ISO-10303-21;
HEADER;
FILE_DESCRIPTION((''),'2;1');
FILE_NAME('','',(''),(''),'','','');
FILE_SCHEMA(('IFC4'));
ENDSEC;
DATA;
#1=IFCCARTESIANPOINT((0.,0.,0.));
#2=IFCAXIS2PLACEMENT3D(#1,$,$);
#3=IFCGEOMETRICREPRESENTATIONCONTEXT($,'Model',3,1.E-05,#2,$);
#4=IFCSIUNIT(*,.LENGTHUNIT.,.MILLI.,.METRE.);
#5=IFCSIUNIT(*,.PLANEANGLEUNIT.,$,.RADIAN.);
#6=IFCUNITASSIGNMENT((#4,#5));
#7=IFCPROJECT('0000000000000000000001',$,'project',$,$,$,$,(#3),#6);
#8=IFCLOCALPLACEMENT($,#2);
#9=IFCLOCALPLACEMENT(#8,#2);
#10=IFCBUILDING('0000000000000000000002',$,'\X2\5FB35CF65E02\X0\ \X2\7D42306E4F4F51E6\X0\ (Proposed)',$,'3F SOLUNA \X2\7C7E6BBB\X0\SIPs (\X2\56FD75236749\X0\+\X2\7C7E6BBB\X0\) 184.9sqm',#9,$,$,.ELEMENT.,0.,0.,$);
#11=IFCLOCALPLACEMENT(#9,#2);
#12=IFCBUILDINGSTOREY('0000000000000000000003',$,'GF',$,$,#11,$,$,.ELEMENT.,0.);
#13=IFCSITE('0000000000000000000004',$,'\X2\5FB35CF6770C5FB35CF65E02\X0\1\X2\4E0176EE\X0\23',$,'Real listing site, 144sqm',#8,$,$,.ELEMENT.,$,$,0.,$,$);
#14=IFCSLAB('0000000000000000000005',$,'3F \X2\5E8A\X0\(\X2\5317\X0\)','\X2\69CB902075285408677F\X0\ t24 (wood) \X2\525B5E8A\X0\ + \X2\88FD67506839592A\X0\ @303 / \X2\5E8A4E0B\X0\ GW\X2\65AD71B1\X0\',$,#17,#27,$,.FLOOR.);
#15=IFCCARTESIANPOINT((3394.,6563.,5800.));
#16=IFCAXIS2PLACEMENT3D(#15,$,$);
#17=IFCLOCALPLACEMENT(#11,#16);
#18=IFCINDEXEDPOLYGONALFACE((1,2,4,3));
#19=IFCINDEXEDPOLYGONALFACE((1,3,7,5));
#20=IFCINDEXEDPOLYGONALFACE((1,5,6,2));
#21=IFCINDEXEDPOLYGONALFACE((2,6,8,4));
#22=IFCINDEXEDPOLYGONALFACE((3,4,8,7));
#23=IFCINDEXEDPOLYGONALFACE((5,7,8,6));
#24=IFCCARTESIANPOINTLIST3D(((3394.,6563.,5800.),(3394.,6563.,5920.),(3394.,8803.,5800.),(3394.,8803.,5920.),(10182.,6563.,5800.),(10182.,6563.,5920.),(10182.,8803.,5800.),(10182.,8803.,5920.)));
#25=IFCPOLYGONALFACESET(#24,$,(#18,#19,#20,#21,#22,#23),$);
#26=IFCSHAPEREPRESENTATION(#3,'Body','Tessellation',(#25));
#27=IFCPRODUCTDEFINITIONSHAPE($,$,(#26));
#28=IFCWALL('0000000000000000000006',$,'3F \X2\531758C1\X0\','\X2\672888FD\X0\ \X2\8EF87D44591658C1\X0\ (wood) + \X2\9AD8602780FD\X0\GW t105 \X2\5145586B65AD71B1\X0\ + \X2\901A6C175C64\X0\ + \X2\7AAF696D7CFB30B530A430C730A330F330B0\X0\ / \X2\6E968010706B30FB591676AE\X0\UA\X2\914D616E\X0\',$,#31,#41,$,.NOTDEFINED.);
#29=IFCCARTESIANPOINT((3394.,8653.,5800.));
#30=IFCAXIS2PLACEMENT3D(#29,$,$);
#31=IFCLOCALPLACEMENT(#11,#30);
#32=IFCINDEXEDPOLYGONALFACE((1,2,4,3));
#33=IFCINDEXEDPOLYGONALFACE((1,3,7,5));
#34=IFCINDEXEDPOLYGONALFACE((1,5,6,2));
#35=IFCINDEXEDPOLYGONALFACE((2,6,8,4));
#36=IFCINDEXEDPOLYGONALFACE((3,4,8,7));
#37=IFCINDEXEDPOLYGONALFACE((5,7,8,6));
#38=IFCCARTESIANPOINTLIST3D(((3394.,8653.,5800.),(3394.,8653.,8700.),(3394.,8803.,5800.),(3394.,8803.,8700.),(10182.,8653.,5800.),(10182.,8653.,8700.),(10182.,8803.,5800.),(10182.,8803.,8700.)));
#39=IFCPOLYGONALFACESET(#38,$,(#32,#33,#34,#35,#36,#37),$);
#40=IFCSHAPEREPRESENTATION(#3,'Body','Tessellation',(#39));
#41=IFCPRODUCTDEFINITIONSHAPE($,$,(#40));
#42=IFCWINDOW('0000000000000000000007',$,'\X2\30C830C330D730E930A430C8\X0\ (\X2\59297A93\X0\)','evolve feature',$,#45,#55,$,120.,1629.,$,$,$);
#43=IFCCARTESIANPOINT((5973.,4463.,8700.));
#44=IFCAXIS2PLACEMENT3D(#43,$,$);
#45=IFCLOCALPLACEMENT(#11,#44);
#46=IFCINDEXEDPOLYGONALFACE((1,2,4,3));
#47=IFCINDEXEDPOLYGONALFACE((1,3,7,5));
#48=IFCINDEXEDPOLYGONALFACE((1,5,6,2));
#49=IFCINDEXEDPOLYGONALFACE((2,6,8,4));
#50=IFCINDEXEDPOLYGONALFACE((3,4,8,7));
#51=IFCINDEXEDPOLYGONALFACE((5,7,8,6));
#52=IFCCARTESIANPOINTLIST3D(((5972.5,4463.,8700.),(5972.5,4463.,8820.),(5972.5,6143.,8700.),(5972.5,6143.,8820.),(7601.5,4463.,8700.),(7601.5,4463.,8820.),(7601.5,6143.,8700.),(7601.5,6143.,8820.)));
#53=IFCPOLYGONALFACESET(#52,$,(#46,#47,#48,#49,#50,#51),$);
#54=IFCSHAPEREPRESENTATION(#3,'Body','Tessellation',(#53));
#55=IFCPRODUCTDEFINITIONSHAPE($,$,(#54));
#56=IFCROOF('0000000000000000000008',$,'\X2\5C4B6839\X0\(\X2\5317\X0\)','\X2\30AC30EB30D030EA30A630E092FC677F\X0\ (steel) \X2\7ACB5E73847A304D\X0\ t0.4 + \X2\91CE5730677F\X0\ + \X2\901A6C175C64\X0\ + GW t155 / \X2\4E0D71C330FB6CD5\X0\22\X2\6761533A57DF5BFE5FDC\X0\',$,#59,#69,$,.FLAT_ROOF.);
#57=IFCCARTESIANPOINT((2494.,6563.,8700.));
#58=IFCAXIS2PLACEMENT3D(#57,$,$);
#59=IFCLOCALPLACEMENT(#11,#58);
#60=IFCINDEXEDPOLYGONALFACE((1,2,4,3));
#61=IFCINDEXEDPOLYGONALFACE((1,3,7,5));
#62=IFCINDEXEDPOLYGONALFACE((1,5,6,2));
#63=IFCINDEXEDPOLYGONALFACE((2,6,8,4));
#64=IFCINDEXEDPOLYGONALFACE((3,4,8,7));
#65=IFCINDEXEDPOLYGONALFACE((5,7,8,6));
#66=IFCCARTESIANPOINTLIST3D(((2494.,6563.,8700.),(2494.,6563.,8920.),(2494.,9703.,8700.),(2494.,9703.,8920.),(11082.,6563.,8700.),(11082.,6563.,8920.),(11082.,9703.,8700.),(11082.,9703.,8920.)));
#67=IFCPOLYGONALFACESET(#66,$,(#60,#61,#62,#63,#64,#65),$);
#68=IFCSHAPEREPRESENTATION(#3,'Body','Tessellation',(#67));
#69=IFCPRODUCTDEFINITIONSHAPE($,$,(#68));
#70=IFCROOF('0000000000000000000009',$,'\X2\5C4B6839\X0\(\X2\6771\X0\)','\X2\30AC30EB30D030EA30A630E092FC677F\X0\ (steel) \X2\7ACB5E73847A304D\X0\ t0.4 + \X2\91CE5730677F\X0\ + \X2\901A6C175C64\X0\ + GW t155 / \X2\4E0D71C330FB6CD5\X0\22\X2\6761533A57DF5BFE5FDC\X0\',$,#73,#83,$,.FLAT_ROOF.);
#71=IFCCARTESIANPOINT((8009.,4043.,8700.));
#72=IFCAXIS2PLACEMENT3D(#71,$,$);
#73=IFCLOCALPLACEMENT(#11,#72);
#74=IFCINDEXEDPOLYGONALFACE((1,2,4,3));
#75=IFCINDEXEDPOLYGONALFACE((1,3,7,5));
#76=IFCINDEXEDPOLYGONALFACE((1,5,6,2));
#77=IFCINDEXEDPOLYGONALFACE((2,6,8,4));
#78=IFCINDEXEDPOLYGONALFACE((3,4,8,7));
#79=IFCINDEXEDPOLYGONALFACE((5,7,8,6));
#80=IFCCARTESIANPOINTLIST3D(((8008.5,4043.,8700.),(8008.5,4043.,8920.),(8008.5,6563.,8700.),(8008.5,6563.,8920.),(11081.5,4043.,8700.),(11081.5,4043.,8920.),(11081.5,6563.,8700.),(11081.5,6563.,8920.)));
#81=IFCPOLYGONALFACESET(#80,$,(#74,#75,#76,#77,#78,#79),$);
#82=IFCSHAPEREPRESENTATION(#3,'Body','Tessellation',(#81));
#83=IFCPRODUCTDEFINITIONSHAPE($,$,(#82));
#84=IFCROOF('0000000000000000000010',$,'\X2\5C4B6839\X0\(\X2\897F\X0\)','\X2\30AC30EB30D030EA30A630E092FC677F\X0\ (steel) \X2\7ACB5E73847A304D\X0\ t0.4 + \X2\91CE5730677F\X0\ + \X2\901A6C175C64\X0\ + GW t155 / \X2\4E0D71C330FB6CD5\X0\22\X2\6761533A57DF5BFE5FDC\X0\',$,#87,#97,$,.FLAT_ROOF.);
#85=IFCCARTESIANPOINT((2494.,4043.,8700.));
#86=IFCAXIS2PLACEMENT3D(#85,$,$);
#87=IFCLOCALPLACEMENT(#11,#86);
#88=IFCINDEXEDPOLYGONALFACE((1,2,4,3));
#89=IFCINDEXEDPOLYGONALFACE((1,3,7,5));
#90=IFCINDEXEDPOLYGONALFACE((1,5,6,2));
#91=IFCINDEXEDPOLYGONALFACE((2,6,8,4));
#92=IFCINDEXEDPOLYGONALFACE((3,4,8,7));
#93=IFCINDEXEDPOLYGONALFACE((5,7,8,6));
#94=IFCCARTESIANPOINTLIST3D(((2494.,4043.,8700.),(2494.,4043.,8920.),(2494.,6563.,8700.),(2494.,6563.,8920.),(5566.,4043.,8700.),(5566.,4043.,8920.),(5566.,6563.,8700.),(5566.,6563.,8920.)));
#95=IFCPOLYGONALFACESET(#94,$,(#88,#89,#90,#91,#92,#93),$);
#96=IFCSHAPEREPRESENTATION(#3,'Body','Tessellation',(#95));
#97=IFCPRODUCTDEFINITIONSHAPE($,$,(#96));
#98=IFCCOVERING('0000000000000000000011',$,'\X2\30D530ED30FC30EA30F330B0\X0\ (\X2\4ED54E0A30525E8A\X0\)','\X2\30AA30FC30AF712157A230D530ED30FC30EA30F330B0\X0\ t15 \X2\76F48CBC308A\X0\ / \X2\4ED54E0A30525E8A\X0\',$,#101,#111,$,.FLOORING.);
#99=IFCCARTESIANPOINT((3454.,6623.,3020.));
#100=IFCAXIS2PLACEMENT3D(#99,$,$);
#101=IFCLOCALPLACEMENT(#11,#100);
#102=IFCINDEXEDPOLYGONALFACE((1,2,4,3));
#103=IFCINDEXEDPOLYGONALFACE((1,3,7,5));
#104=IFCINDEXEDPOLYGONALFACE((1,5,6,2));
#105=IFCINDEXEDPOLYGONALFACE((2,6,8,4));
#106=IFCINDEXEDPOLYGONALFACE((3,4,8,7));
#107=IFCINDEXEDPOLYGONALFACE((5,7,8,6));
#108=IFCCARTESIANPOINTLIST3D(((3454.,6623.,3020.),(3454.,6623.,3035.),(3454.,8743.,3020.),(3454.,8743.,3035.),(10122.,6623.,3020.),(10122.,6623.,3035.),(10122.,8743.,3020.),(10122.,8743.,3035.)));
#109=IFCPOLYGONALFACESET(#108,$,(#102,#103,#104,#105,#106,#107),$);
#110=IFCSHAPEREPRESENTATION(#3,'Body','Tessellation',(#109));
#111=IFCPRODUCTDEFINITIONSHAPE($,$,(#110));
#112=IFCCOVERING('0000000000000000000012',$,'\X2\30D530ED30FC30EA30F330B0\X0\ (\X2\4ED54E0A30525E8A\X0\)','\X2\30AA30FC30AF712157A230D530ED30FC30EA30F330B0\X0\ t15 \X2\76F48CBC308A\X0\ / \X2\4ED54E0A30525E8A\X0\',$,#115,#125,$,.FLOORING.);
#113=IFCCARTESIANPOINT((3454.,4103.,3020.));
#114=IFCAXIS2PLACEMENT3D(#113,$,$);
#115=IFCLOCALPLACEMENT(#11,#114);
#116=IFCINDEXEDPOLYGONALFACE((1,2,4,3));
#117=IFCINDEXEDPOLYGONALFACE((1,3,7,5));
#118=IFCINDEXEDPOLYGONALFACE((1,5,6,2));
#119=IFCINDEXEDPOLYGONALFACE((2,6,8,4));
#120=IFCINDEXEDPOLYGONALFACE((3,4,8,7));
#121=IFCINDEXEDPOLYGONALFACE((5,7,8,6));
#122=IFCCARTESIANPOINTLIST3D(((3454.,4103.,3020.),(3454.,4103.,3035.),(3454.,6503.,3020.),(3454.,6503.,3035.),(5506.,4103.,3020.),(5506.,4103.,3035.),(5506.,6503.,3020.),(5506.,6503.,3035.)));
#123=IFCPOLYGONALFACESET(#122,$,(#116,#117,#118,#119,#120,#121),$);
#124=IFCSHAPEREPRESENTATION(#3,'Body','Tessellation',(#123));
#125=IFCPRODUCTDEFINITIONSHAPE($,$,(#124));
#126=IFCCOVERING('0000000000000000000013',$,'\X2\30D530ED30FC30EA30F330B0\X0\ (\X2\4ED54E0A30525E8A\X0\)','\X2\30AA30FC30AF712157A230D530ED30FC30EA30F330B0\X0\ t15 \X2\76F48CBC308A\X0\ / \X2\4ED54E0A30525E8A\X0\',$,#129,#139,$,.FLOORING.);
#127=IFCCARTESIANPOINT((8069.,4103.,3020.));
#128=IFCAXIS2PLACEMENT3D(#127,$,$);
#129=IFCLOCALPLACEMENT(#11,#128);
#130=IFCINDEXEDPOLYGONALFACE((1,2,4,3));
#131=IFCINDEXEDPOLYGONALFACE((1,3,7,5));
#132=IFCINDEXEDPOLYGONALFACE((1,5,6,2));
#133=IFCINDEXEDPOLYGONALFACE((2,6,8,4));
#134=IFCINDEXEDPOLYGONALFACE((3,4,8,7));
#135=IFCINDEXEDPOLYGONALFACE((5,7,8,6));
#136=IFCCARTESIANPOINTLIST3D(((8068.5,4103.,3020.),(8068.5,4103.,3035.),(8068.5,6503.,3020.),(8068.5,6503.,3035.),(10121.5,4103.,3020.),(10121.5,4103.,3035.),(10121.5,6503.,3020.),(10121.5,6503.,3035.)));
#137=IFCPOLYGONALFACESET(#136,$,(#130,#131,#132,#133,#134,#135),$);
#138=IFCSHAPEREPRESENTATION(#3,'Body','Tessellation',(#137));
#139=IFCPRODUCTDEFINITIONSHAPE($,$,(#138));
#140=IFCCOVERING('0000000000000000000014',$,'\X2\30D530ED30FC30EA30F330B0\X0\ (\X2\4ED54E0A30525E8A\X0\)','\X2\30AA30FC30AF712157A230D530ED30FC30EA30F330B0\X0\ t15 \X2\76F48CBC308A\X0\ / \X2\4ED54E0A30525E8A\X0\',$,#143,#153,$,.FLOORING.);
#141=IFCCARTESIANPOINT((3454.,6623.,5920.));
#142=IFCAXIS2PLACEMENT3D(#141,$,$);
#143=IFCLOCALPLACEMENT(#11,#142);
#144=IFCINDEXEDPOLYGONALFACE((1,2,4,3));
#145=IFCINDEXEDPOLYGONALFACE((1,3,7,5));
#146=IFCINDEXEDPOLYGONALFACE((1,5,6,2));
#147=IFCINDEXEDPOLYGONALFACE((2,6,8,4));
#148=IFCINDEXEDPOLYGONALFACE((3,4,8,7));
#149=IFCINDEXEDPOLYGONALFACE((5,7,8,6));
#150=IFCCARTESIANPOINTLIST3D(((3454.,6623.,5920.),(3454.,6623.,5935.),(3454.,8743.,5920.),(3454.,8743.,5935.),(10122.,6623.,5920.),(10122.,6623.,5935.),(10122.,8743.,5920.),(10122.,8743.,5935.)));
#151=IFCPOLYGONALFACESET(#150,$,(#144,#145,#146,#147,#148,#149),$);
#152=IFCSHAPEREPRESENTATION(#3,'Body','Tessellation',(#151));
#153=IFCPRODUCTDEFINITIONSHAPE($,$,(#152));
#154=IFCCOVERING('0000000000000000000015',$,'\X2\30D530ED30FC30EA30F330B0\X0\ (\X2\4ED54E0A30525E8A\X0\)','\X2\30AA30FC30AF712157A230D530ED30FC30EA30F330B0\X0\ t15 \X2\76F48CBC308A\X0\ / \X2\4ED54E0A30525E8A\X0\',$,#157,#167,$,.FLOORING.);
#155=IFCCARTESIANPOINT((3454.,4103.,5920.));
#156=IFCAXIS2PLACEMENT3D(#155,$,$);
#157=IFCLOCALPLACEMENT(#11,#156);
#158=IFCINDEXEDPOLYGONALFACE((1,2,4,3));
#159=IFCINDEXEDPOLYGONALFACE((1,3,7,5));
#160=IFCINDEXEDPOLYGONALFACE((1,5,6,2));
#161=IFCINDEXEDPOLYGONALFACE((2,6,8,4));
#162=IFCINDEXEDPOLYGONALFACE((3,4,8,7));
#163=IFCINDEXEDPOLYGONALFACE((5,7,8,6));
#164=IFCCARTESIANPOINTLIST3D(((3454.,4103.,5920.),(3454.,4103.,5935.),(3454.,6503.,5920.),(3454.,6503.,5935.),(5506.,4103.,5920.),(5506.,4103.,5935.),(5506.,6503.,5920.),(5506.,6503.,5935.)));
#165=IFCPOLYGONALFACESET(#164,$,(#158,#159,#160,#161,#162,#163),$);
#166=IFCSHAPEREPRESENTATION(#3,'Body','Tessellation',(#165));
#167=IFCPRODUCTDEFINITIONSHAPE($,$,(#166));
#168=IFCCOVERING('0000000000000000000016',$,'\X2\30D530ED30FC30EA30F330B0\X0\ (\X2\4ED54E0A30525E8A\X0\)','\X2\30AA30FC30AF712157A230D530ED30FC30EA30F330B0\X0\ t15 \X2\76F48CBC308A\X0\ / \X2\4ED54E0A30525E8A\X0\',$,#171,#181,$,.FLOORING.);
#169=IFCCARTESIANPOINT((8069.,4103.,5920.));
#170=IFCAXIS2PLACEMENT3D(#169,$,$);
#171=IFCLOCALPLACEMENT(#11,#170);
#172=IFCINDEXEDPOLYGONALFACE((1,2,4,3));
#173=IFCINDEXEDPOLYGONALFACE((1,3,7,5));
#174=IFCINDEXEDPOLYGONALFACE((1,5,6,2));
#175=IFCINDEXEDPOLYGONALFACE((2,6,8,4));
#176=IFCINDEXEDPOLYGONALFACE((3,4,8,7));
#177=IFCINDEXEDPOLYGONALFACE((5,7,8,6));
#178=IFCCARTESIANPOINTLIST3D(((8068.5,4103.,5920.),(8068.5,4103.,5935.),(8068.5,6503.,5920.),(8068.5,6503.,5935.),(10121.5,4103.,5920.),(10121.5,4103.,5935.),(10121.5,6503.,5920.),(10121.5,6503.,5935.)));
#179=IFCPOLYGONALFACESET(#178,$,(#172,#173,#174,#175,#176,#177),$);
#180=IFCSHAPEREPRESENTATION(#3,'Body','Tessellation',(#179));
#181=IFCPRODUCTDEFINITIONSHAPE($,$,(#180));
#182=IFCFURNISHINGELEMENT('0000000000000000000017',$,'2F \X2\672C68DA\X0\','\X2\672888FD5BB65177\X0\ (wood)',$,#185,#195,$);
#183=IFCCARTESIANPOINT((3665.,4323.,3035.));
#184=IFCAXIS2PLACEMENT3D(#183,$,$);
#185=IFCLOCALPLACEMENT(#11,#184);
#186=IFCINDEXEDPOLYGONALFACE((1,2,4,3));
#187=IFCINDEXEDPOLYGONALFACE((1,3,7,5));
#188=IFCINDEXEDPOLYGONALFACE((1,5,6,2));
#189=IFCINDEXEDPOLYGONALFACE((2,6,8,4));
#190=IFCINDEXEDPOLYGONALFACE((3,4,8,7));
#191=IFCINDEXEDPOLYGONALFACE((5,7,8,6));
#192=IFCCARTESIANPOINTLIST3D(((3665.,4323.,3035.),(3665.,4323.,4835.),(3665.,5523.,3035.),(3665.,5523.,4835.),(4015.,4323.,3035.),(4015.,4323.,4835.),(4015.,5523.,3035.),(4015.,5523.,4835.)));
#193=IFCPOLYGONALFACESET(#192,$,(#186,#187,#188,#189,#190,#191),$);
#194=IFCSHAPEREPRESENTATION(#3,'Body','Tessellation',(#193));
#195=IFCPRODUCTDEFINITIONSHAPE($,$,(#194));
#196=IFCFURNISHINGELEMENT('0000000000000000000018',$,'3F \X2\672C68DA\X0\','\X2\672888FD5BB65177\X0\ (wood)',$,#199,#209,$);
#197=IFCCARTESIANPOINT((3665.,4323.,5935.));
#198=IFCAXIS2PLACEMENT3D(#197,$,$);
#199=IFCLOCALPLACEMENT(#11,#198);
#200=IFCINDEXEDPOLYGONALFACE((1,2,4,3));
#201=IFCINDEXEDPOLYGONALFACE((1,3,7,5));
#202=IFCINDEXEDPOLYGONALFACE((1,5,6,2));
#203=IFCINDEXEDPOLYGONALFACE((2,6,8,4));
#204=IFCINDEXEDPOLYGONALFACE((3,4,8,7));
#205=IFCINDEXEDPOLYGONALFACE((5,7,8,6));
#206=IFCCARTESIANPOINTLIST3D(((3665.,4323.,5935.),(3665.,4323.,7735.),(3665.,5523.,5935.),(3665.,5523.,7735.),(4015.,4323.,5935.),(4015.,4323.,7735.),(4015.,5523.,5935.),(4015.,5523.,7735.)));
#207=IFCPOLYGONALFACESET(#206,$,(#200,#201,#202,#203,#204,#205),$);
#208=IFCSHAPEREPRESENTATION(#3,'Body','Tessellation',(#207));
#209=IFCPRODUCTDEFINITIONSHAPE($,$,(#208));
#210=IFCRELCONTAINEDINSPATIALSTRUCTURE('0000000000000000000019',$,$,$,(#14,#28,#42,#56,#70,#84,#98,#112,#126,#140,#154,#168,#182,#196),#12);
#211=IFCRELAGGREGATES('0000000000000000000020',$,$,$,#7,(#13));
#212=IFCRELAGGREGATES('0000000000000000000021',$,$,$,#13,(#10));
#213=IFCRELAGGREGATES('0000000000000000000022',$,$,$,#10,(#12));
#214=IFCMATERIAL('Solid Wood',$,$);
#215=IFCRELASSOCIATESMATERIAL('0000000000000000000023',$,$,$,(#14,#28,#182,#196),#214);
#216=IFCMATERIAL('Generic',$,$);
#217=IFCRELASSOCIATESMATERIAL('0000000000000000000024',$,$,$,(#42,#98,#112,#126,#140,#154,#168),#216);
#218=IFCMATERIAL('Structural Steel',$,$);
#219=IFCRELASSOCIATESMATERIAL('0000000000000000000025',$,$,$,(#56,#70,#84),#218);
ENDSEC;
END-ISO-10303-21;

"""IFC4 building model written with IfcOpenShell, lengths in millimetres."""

from ifc_helpers import new_model, si_unit, frame, frame_2d, origin, place, context, project, spatial, rectangle, extrude, material, element, save


model = new_model("IFC4")

# Units and contexts
model_context = context("Model", 3, precision=1e-05, world=origin())
ifc_project = project(units=[si_unit("LENGTHUNIT", "METRE", prefix="MILLI"), si_unit("PLANEANGLEUNIT", "RADIAN")], contexts=[model_context])

# Site, building, storey
site_placement = place(None, origin())
site = spatial("IfcSite", under=ifc_project, at=site_placement, Name="徳島県徳島市1丁目23", ObjectType="Real listing site, 144sqm", CompositionType="ELEMENT", RefElevation=0.0)
building_placement = place(site_placement, origin())
building = spatial("IfcBuilding", under=site, at=building_placement, Name="徳島市 終の住処 (Proposed)", ObjectType="3F SOLUNA 籾殻SIPs (国産杉+籾殻) 184.9sqm", CompositionType="ELEMENT", ElevationOfRefHeight=0.0, ElevationOfTerrain=0.0)
storey_placement = place(building_placement, origin())
storey = spatial("IfcBuildingStorey", under=building, at=storey_placement, Name="GF", CompositionType="ELEMENT", Elevation=0.0)

# Slab
ifc_material_1 = material(Name="Solid Wood")
slab_placement = place(storey_placement, frame((3394.0, 6563.0, 5800.0)))
element("IfcSlab", 1, at=slab_placement, inside=storey, material=ifc_material_1, Name="3F 床(北)", Description="構造用合板 t24 (wood) 剛床 + 製材根太 @303 / 床下 GW断熱", PredefinedType="FLOOR", context=model_context, shape_type="SweptSolid", body=[
    extrude(rectangle(XDim=6788.0, YDim=2240.0, at=frame_2d((3394.0, 1120.0))), frame((3394.0, 6563.0, 5800.0)), (0.0, 0.0, 1.0), 120.0),
])

# Wall
wall_1_placement = place(storey_placement, frame((3394.0, 8653.0, 5800.0)))
element("IfcWall", 2, at=wall_1_placement, inside=storey, material=ifc_material_1, Name="3F 北壁", Description="木製 軸組外壁 (wood) + 高性能GW t105 充填断熱 + 通気層 + 窯業系サイディング / 準耐火・外皮UA配慮", PredefinedType="NOTDEFINED", context=model_context, shape_type="SweptSolid", body=[
    extrude(rectangle(XDim=6788.0, YDim=150.0, at=frame_2d((3394.0, 75.0))), frame((3394.0, 8653.0, 5800.0)), (0.0, 0.0, 1.0), 2900.0),
])

# Window
ifc_material_2 = material(Name="Generic")
window_1_placement = place(storey_placement, frame((5973.0, 4463.0, 8700.0)))
element("IfcWindow", 3, at=window_1_placement, inside=storey, material=ifc_material_2, Name="トップライト (天窓)", Description="evolve feature", OverallHeight=120.0, OverallWidth=1629.0, context=model_context, shape_type="SweptSolid", body=[
    extrude(rectangle(XDim=1629.0, YDim=1680.0, at=frame_2d((814.0, 840.0))), frame((5973.0, 4463.0, 8700.0)), (0.0, 0.0, 1.0), 120.0),
])

# Roofs
ifc_material_3 = material(Name="Structural Steel")
roof_1_placement = place(storey_placement, frame((2494.0, 6563.0, 8700.0)))
element("IfcRoof", 4, at=roof_1_placement, inside=storey, material=ifc_material_3, Name="屋根(北)", Description="ガルバリウム鋼板 (steel) 立平葺き t0.4 + 野地板 + 通気層 + GW t155 / 不燃・法22条区域対応", PredefinedType="FLAT_ROOF", context=model_context, shape_type="SweptSolid", body=[
    extrude(rectangle(XDim=8588.0, YDim=3140.0, at=frame_2d((4294.0, 1570.0))), frame((2494.0, 6563.0, 8700.0)), (0.0, 0.0, 1.0), 220.0),
])
roof_2_placement = place(storey_placement, frame((8009.0, 4043.0, 8700.0)))
element("IfcRoof", 5, at=roof_2_placement, inside=storey, material=ifc_material_3, Name="屋根(東)", Description="ガルバリウム鋼板 (steel) 立平葺き t0.4 + 野地板 + 通気層 + GW t155 / 不燃・法22条区域対応", PredefinedType="FLAT_ROOF", context=model_context, shape_type="SweptSolid", body=[
    extrude(rectangle(XDim=3073.0, YDim=2520.0, at=frame_2d((1536.0, 1260.0))), frame((8009.0, 4043.0, 8700.0)), (0.0, 0.0, 1.0), 220.0),
])
roof_3_placement = place(storey_placement, frame((2494.0, 4043.0, 8700.0)))
element("IfcRoof", 6, at=roof_3_placement, inside=storey, material=ifc_material_3, Name="屋根(西)", Description="ガルバリウム鋼板 (steel) 立平葺き t0.4 + 野地板 + 通気層 + GW t155 / 不燃・法22条区域対応", PredefinedType="FLAT_ROOF", context=model_context, shape_type="SweptSolid", body=[
    extrude(rectangle(XDim=3072.0, YDim=2520.0, at=frame_2d((1536.0, 1260.0))), frame((2494.0, 4043.0, 8700.0)), (0.0, 0.0, 1.0), 220.0),
])

# Coverings
covering_1_placement = place(storey_placement, frame((3454.0, 6623.0, 3020.0)))
element("IfcCovering", 7, at=covering_1_placement, inside=storey, material=ifc_material_2, Name="フローリング (仕上げ床)", Description="オーク無垢フローリング t15 直貼り / 仕上げ床", PredefinedType="FLOORING", context=model_context, shape_type="SweptSolid", body=[
    extrude(rectangle(XDim=6668.0, YDim=2120.0, at=frame_2d((3334.0, 1060.0))), frame((3454.0, 6623.0, 3020.0)), (0.0, 0.0, 1.0), 15.0),
])
covering_2_placement = place(storey_placement, frame((3454.0, 4103.0, 3020.0)))
element("IfcCovering", 8, at=covering_2_placement, inside=storey, material=ifc_material_2, Name="フローリング (仕上げ床)", Description="オーク無垢フローリング t15 直貼り / 仕上げ床", PredefinedType="FLOORING", context=model_context, shape_type="SweptSolid", body=[
    extrude(rectangle(XDim=2052.0, YDim=2400.0, at=frame_2d((1026.0, 1200.0))), frame((3454.0, 4103.0, 3020.0)), (0.0, 0.0, 1.0), 15.0),
])
covering_3_placement = place(storey_placement, frame((8069.0, 4103.0, 3020.0)))
element("IfcCovering", 9, at=covering_3_placement, inside=storey, material=ifc_material_2, Name="フローリング (仕上げ床)", Description="オーク無垢フローリング t15 直貼り / 仕上げ床", PredefinedType="FLOORING", context=model_context, shape_type="SweptSolid", body=[
    extrude(rectangle(XDim=2053.0, YDim=2400.0, at=frame_2d((1026.0, 1200.0))), frame((8069.0, 4103.0, 3020.0)), (0.0, 0.0, 1.0), 15.0),
])
covering_4_placement = place(storey_placement, frame((3454.0, 6623.0, 5920.0)))
element("IfcCovering", 10, at=covering_4_placement, inside=storey, material=ifc_material_2, Name="フローリング (仕上げ床)", Description="オーク無垢フローリング t15 直貼り / 仕上げ床", PredefinedType="FLOORING", context=model_context, shape_type="SweptSolid", body=[
    extrude(rectangle(XDim=6668.0, YDim=2120.0, at=frame_2d((3334.0, 1060.0))), frame((3454.0, 6623.0, 5920.0)), (0.0, 0.0, 1.0), 15.0),
])
covering_5_placement = place(storey_placement, frame((3454.0, 4103.0, 5920.0)))
element("IfcCovering", 11, at=covering_5_placement, inside=storey, material=ifc_material_2, Name="フローリング (仕上げ床)", Description="オーク無垢フローリング t15 直貼り / 仕上げ床", PredefinedType="FLOORING", context=model_context, shape_type="SweptSolid", body=[
    extrude(rectangle(XDim=2052.0, YDim=2400.0, at=frame_2d((1026.0, 1200.0))), frame((3454.0, 4103.0, 5920.0)), (0.0, 0.0, 1.0), 15.0),
])
covering_6_placement = place(storey_placement, frame((8069.0, 4103.0, 5920.0)))
element("IfcCovering", 12, at=covering_6_placement, inside=storey, material=ifc_material_2, Name="フローリング (仕上げ床)", Description="オーク無垢フローリング t15 直貼り / 仕上げ床", PredefinedType="FLOORING", context=model_context, shape_type="SweptSolid", body=[
    extrude(rectangle(XDim=2053.0, YDim=2400.0, at=frame_2d((1026.0, 1200.0))), frame((8069.0, 4103.0, 5920.0)), (0.0, 0.0, 1.0), 15.0),
])

# Furnishing elements
furnishing_1_placement = place(storey_placement, frame((3665.0, 4323.0, 3035.0)))
element("IfcFurnishingElement", 13, at=furnishing_1_placement, inside=storey, material=ifc_material_1, Name="2F 本棚", Description="木製家具 (wood)", context=model_context, shape_type="SweptSolid", body=[
    extrude(rectangle(XDim=350.0, YDim=1200.0, at=frame_2d((175.0, 600.0))), frame((3665.0, 4323.0, 3035.0)), (0.0, 0.0, 1.0), 1800.0),
])
furnishing_2_placement = place(storey_placement, frame((3665.0, 4323.0, 5935.0)))
element("IfcFurnishingElement", 14, at=furnishing_2_placement, inside=storey, material=ifc_material_1, Name="3F 本棚", Description="木製家具 (wood)", context=model_context, shape_type="SweptSolid", body=[
    extrude(rectangle(XDim=350.0, YDim=1200.0, at=frame_2d((175.0, 600.0))), frame((3665.0, 4323.0, 5935.0)), (0.0, 0.0, 1.0), 1800.0),
])

save(model, "model.ifc")
